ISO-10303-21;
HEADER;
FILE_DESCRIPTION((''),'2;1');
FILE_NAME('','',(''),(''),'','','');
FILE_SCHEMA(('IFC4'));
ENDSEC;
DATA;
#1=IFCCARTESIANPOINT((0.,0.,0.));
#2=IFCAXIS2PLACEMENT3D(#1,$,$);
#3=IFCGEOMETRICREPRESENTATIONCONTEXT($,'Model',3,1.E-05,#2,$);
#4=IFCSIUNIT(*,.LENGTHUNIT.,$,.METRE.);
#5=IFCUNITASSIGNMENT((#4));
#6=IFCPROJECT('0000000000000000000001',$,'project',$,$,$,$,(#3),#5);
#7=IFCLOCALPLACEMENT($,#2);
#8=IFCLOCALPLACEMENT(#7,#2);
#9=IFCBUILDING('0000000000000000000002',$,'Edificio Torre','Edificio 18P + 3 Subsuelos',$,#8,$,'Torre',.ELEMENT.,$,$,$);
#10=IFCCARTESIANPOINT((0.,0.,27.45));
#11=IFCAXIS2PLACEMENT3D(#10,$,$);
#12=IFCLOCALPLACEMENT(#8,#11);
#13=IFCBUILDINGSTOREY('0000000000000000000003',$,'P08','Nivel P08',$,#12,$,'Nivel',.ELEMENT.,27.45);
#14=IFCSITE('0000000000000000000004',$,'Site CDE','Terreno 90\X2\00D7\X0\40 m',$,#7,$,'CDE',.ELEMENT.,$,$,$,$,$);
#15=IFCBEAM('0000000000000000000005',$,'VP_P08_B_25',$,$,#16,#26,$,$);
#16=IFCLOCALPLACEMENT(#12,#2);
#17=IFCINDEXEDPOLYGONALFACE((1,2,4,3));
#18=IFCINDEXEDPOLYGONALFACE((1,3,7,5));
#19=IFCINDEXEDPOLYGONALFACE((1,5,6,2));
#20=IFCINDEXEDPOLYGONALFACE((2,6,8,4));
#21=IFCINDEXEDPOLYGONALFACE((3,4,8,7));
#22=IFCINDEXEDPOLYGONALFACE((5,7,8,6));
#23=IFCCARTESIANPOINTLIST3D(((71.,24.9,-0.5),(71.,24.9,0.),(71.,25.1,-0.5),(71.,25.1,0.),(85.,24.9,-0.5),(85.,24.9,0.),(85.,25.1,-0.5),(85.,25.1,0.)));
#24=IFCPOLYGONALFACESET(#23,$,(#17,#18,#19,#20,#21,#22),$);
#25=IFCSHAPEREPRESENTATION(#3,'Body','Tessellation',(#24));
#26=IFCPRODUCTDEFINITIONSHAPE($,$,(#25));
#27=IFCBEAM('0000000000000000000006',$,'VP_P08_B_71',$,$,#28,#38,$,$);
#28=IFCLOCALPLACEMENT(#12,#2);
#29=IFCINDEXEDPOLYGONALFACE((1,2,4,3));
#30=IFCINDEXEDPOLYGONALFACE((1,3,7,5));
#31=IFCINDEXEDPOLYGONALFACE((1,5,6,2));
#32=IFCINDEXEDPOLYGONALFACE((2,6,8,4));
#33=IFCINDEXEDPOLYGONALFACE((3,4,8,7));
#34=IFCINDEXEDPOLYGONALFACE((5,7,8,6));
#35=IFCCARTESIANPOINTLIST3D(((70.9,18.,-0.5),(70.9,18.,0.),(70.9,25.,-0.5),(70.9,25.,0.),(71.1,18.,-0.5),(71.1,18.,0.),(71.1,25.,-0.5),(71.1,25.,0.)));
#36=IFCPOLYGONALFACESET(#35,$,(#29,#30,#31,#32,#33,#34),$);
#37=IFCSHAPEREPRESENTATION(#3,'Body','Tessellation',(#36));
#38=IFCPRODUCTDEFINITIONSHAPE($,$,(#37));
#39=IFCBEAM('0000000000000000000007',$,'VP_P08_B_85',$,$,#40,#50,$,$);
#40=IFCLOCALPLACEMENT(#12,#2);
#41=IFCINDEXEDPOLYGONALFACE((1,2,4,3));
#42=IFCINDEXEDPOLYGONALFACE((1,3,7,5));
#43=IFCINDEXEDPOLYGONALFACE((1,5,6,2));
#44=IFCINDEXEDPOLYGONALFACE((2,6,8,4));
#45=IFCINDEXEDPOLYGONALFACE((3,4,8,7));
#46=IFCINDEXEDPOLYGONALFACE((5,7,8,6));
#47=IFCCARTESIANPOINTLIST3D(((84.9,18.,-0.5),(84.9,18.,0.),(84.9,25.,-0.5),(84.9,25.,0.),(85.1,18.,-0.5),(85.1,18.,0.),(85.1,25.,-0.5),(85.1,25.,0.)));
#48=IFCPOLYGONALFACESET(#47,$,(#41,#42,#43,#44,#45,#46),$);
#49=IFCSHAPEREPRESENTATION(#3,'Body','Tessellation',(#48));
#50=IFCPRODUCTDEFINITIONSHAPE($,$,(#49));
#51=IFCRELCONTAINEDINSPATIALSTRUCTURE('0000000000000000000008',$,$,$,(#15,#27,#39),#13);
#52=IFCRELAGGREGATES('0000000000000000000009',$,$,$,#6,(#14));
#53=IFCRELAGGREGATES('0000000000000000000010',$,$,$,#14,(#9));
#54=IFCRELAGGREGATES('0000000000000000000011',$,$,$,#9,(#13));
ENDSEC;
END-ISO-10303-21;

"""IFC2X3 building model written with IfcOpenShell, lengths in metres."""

from ifc_helpers import new_model, si_unit, frame, origin, origin_2d, place, context, project, spatial, rectangle, extrude, element, save


model = new_model("IFC2X3")

# Units and contexts
model_context = context("Model", 3, precision=1e-05, world=origin())
ifc_project = project(units=[si_unit("LENGTHUNIT", "METRE")], contexts=[model_context])

# Site, building, storey
site_placement = place(None, origin())
site = spatial("IfcSite", under=ifc_project, at=site_placement, Name="Site CDE", Description="Terreno 90×40 m", LongName="CDE", CompositionType="ELEMENT")
building_placement = place(site_placement, origin())
building = spatial("IfcBuilding", under=site, at=building_placement, Name="Edificio Torre", Description="Edificio 18P + 3 Subsuelos", LongName="Torre", CompositionType="ELEMENT")
storey_placement = place(building_placement, frame((0.0, 0.0, 27.45)))
storey = spatial("IfcBuildingStorey", under=building, at=storey_placement, Name="P08", Description="Nivel P08", LongName="Nivel", CompositionType="ELEMENT", Elevation=27.45)

# Beams
for number, where, name in (
    (1, (78.0, 25.0, -0.5), "VP_P08_B_25"),
):
    element("IfcBeam", number, at=place(storey_placement, frame(where)), inside=storey, Name=name, context=model_context, shape_type="SweptSolid", body=[
        extrude(rectangle(XDim=14.0, YDim=0.2, at=origin_2d()), origin(), (0.0, 0.0, 1.0), 0.5),
    ])
for number, where, name in (
    (2, (71.0, 21.5, -0.5), "VP_P08_B_71"),
    (3, (85.0, 21.5, -0.5), "VP_P08_B_85"),
):
    element("IfcBeam", number, at=place(storey_placement, frame(where)), inside=storey, Name=name, context=model_context, shape_type="SweptSolid", body=[
        extrude(rectangle(XDim=0.2, YDim=7.0, at=origin_2d()), origin(), (0.0, 0.0, 1.0), 0.5),
    ])

save(model, "model.ifc")
